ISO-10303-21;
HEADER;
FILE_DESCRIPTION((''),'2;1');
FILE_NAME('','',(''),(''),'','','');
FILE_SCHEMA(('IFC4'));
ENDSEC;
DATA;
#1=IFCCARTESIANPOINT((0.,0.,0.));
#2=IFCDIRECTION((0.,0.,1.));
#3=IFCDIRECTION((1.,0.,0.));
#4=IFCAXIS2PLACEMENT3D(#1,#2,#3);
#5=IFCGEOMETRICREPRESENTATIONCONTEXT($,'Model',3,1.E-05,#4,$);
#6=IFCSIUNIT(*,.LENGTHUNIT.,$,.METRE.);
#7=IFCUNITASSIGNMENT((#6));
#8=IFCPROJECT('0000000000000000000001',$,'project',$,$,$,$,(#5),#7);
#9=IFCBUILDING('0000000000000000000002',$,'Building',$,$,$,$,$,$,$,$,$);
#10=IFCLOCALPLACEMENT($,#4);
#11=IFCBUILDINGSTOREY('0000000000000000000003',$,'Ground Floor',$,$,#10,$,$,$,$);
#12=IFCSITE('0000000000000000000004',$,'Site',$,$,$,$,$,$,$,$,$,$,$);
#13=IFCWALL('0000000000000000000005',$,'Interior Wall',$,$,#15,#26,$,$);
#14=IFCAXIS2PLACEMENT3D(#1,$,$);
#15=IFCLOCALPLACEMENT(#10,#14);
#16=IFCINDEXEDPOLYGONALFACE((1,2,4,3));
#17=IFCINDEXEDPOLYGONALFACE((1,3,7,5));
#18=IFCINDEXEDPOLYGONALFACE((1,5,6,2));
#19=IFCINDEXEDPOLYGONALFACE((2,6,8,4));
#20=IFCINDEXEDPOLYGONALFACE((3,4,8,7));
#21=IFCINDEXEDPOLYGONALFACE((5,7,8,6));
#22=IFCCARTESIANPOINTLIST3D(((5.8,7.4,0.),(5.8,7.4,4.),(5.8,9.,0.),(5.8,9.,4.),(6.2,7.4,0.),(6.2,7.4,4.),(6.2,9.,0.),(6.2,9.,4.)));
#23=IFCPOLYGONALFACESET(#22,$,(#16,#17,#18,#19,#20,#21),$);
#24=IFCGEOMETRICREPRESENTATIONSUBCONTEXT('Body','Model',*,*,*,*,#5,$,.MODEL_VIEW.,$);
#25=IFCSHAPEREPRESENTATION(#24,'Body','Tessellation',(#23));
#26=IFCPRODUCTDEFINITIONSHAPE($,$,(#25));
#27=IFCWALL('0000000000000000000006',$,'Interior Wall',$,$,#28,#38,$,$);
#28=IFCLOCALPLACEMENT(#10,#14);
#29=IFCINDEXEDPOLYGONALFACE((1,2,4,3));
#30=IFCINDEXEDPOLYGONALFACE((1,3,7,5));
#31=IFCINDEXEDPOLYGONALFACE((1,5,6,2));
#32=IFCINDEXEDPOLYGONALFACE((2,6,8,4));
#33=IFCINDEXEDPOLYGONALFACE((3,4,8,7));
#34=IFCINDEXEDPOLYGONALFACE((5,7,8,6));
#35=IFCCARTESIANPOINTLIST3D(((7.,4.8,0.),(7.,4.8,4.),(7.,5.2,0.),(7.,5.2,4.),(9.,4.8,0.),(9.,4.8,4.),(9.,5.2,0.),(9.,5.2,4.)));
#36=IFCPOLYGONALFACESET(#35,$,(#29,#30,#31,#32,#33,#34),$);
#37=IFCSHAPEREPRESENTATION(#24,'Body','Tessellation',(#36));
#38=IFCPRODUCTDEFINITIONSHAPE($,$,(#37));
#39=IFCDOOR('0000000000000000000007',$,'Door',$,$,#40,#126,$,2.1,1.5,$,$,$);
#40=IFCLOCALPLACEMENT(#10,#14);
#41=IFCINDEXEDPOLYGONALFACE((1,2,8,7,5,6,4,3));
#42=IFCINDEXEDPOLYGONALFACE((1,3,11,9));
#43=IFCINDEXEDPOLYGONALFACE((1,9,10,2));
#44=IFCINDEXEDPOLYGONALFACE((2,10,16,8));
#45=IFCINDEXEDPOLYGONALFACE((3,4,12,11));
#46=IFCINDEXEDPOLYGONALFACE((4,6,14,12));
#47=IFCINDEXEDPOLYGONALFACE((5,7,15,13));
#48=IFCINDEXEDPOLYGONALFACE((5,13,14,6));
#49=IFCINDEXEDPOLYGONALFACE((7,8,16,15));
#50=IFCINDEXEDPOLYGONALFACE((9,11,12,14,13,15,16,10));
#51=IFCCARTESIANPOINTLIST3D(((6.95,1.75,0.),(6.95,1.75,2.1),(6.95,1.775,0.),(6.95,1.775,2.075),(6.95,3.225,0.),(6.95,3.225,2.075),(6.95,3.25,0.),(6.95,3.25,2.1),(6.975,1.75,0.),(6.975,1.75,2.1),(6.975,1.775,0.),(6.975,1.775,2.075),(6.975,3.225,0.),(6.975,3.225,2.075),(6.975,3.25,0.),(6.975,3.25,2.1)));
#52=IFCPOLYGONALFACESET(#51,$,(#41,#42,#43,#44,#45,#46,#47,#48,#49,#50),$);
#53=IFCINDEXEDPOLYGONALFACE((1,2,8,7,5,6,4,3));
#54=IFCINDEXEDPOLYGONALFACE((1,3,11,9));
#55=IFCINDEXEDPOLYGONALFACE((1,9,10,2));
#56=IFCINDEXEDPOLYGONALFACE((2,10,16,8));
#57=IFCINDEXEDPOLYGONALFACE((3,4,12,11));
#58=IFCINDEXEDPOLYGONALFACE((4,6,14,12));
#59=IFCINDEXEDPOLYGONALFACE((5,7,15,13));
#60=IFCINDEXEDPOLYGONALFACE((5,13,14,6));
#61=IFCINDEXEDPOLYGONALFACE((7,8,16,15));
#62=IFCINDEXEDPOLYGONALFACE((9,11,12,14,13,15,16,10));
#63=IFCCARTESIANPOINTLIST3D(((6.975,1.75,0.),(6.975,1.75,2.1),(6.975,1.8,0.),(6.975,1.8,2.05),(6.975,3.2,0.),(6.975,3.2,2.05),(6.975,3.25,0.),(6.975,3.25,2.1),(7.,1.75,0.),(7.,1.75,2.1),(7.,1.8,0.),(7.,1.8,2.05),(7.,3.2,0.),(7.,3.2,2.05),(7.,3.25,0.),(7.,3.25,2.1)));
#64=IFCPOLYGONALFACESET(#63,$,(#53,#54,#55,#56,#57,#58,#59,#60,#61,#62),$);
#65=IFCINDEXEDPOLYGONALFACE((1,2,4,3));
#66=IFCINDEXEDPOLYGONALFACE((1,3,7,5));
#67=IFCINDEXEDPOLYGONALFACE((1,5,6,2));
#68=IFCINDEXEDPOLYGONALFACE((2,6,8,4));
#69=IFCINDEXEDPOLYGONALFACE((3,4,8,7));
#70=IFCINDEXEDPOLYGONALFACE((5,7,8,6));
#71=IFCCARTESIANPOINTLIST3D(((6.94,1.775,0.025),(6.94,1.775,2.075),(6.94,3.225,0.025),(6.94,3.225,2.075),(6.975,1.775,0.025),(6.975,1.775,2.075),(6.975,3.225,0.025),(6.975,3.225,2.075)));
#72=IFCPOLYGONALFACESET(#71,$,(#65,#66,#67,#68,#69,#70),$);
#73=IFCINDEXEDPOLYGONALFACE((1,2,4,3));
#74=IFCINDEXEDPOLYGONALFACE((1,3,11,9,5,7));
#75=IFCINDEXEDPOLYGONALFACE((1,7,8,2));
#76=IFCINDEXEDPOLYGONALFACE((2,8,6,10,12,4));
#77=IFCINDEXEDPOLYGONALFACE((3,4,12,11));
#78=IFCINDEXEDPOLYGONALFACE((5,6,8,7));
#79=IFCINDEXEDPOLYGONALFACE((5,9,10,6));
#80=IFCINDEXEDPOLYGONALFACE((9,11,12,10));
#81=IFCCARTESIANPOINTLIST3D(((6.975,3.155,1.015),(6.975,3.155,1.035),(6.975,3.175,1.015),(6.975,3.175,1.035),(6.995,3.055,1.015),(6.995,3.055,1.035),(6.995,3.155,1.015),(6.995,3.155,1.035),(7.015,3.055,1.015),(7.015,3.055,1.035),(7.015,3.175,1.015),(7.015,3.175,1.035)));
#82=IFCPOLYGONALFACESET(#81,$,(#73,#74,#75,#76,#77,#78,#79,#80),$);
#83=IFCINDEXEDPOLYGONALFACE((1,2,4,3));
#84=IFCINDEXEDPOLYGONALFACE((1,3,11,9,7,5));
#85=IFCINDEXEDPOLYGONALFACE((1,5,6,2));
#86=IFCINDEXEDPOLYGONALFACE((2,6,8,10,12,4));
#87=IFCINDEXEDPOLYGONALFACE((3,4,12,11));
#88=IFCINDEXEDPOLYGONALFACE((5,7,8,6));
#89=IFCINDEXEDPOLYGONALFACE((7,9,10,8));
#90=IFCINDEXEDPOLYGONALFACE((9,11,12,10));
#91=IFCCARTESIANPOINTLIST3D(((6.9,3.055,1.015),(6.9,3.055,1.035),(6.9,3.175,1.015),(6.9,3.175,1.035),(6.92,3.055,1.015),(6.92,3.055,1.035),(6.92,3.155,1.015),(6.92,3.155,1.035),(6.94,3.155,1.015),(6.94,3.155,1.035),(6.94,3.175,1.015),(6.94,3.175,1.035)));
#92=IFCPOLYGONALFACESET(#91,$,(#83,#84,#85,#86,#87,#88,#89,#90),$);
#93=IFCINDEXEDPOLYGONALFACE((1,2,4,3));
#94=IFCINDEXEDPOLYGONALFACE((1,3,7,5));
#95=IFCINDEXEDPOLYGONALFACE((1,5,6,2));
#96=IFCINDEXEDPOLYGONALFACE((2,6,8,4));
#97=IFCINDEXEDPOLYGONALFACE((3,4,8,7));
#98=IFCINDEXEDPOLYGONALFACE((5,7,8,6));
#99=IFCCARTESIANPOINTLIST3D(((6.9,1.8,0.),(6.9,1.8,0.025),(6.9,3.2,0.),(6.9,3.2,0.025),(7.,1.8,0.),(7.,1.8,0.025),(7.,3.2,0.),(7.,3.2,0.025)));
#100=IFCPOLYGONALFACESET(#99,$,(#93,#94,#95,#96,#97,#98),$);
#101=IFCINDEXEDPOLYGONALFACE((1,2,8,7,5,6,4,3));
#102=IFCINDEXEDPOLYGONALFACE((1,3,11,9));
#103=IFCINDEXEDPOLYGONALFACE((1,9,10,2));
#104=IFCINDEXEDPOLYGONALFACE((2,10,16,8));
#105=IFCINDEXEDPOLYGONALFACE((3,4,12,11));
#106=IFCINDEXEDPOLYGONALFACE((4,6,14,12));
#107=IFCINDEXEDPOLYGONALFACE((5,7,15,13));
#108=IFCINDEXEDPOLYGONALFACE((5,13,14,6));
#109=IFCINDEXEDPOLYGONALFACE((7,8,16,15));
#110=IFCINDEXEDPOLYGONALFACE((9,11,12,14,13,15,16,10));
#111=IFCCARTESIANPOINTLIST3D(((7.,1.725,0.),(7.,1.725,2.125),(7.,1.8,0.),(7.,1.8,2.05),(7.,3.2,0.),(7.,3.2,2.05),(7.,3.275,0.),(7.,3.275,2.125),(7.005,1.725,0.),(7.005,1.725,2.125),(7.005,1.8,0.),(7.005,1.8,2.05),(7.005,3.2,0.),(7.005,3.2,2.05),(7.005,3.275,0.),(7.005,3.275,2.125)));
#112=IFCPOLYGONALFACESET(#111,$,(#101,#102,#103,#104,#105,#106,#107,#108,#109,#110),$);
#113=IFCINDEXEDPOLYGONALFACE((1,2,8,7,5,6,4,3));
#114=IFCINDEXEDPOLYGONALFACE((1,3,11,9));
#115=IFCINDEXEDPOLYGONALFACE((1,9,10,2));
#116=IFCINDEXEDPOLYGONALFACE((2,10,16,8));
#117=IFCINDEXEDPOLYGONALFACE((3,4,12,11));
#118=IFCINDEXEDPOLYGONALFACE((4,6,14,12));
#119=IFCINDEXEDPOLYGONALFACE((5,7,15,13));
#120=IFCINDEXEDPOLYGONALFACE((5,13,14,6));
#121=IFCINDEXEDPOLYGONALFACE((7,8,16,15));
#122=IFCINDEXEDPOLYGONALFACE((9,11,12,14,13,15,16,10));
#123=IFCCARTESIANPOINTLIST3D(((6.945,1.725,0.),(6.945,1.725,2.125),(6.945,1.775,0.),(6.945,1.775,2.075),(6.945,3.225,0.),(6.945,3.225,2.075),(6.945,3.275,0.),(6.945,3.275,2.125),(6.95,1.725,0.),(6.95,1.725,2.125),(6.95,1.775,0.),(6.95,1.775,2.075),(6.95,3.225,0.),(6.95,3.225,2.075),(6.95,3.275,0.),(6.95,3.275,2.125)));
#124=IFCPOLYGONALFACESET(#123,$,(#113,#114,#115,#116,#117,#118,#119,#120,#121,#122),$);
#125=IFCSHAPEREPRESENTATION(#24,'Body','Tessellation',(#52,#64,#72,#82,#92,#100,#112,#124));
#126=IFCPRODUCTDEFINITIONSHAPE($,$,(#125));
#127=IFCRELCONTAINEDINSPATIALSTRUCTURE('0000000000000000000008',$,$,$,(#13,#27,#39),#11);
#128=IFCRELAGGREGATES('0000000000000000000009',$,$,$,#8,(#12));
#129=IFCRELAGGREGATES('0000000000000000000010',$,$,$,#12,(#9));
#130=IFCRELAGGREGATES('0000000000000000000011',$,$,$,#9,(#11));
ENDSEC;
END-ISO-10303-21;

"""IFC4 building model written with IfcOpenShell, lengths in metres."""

from ifc_helpers import new_model, si_unit, frame, origin_with_axes, place, context, subcontext, project, spatial, line, indexed_curve, outline, extrude, element, save


model = new_model("IFC4")

# Units and contexts
model_context = context("Model", 3, precision=1e-05, world=origin_with_axes())
body_context = subcontext(model_context, "Body", "Model", "MODEL_VIEW")
ifc_project = project(units=[si_unit("LENGTHUNIT", "METRE")], contexts=[model_context])

# Site, building, storey
site = spatial("IfcSite", under=ifc_project, Name="Site")
building = spatial("IfcBuilding", under=site, Name="Building")
storey_placement = place(None, origin_with_axes())
storey = spatial("IfcBuildingStorey", under=building, at=storey_placement, Name="Ground Floor")

# Walls
for number, where, z_axis, x_axis, name in (
    (1, (6.0, 7.4, 0.0), (0.0, 0.0, 1.0), (0.0, 1.0, 0.0), "Interior Wall"),
):
    element("IfcWall", number, at=place(storey_placement, frame(where, z_axis=z_axis, x_axis=x_axis)), inside=storey, Name=name, context=body_context, shape_type="SweptSolid", body=[
        extrude(outline(indexed_curve([(0.0, 0.0), (0.0, 0.4), (1.6, 0.4), (1.6, 0.0), (0.0, 0.0)], self_intersect=False)), frame((0.0, -0.2, 0.0), z_axis=(0.0, 0.0, 1.0), x_axis=(1.0, 0.0, 0.0)), (0.0, 0.0, 1.0), 4.0),
    ])
wall_1_placement = place(storey_placement, frame((7.0, 5.0, 0.0), z_axis=(0.0, 0.0, 1.0), x_axis=(1.0, 0.0, 0.0)))
element("IfcWall", 2, at=wall_1_placement, inside=storey, Name="Interior Wall", context=body_context, shape_type="SweptSolid", body=[
    extrude(outline(indexed_curve([(0.0, 0.0), (0.0, 0.4), (2.0, 0.4), (2.0, 0.0), (0.0, 0.0)], self_intersect=False)), frame((0.0, -0.2, 0.0), z_axis=(0.0, 0.0, 1.0), x_axis=(1.0, 0.0, 0.0)), (0.0, 0.0, 1.0), 4.0),
])

# Door
door_1_placement = place(storey_placement, frame((7.0, 1.75, 0.0), z_axis=(0.0, 0.0, 1.0), x_axis=(0.0, 1.0, 0.0)))
element("IfcDoor", 3, at=door_1_placement, inside=storey, Name="Door", OverallHeight=2.1, OverallWidth=1.5, context=body_context, shape_type="SweptSolid", body=[
    extrude(outline(indexed_curve([(0.0, 0.0), (0.0, 2.1), (1.5, 2.1), (1.5, 0.0), (1.475, 0.0), (1.475, 2.075), (0.025, 2.075), (0.025, 0.0)], segments=[line(1, 2, 3, 4, 5, 6, 7, 8, 1)])), frame((0.0, 0.025, 0.0), z_axis=(0.0, -1.0, 0.0), x_axis=(1.0, 0.0, 0.0)), (0.0, 0.0, -1.0), 0.025),
    extrude(outline(indexed_curve([(0.0, 0.0), (0.0, 2.1), (1.5, 2.1), (1.5, 0.0), (1.45, 0.0), (1.45, 2.05), (0.05, 2.05), (0.05, 0.0)], segments=[line(1, 2, 3, 4, 5, 6, 7, 8, 1)])), frame((0.0, 0.0, 0.0), z_axis=(0.0, -1.0, 0.0), x_axis=(1.0, 0.0, 0.0)), (0.0, 0.0, -1.0), 0.025),
    extrude(outline(indexed_curve([(0.0, 0.0), (1.45, 0.0), (1.45, 0.035), (0.0, 0.035)], segments=[line(1, 2, 3, 4, 1)])), frame((0.025, 0.025, 0.025), z_axis=(0.0, 0.0, 1.0), x_axis=(1.0, 0.0, 0.0)), (0.0, 0.0, 1.0), 2.05),
    extrude(outline(indexed_curve([(0.0, 0.0), (0.0, -0.04), (-0.12, -0.04), (-0.12, -0.02), (-0.02, -0.02), (-0.02, 0.0)], segments=[line(1, 2, 3, 4, 5, 6, 1)])), frame((1.425, 0.025, 1.015), z_axis=(0.0, 0.0, 1.0), x_axis=(1.0, 0.0, 0.0)), (0.0, 0.0, 1.0), 0.02),
    extrude(outline(indexed_curve([(0.0, 0.0), (0.0, 0.04), (-0.12, 0.04), (-0.12, 0.02), (-0.02, 0.02), (-0.02, 0.0)], segments=[line(1, 2, 3, 4, 5, 6, 1)])), frame((1.425, 0.06, 1.015), z_axis=(0.0, 0.0, 1.0), x_axis=(1.0, 0.0, 0.0)), (0.0, 0.0, 1.0), 0.02),
    extrude(outline(indexed_curve([(0.0, 0.0), (1.4, 0.0), (1.4, 0.1), (0.0, 0.1)], segments=[line(1, 2, 3, 4, 1)])), frame((0.05, 0.0, 0.0), z_axis=(0.0, 0.0, 1.0), x_axis=(1.0, 0.0, 0.0)), (0.0, 0.0, 1.0), 0.025),
    extrude(outline(indexed_curve([(0.0, 0.0), (0.0, 2.125), (1.55, 2.125), (1.55, 0.0), (1.475, 0.0), (1.475, 2.05), (0.075, 2.05), (0.075, 0.0)], segments=[line(1, 2, 3, 4, 5, 6, 7, 8, 1)])), frame((-0.025, -0.005, 0.0), z_axis=(0.0, -1.0, 0.0), x_axis=(1.0, 0.0, 0.0)), (0.0, 0.0, -1.0), 0.005),
    extrude(outline(indexed_curve([(0.0, 0.0), (0.0, 2.125), (1.55, 2.125), (1.55, 0.0), (1.5, 0.0), (1.5, 2.075), (0.05, 2.075), (0.05, 0.0)], segments=[line(1, 2, 3, 4, 5, 6, 7, 8, 1)])), frame((-0.025, 0.05, 0.0), z_axis=(0.0, -1.0, 0.0), x_axis=(1.0, 0.0, 0.0)), (0.0, 0.0, -1.0), 0.005),
])

save(model, "model.ifc")
